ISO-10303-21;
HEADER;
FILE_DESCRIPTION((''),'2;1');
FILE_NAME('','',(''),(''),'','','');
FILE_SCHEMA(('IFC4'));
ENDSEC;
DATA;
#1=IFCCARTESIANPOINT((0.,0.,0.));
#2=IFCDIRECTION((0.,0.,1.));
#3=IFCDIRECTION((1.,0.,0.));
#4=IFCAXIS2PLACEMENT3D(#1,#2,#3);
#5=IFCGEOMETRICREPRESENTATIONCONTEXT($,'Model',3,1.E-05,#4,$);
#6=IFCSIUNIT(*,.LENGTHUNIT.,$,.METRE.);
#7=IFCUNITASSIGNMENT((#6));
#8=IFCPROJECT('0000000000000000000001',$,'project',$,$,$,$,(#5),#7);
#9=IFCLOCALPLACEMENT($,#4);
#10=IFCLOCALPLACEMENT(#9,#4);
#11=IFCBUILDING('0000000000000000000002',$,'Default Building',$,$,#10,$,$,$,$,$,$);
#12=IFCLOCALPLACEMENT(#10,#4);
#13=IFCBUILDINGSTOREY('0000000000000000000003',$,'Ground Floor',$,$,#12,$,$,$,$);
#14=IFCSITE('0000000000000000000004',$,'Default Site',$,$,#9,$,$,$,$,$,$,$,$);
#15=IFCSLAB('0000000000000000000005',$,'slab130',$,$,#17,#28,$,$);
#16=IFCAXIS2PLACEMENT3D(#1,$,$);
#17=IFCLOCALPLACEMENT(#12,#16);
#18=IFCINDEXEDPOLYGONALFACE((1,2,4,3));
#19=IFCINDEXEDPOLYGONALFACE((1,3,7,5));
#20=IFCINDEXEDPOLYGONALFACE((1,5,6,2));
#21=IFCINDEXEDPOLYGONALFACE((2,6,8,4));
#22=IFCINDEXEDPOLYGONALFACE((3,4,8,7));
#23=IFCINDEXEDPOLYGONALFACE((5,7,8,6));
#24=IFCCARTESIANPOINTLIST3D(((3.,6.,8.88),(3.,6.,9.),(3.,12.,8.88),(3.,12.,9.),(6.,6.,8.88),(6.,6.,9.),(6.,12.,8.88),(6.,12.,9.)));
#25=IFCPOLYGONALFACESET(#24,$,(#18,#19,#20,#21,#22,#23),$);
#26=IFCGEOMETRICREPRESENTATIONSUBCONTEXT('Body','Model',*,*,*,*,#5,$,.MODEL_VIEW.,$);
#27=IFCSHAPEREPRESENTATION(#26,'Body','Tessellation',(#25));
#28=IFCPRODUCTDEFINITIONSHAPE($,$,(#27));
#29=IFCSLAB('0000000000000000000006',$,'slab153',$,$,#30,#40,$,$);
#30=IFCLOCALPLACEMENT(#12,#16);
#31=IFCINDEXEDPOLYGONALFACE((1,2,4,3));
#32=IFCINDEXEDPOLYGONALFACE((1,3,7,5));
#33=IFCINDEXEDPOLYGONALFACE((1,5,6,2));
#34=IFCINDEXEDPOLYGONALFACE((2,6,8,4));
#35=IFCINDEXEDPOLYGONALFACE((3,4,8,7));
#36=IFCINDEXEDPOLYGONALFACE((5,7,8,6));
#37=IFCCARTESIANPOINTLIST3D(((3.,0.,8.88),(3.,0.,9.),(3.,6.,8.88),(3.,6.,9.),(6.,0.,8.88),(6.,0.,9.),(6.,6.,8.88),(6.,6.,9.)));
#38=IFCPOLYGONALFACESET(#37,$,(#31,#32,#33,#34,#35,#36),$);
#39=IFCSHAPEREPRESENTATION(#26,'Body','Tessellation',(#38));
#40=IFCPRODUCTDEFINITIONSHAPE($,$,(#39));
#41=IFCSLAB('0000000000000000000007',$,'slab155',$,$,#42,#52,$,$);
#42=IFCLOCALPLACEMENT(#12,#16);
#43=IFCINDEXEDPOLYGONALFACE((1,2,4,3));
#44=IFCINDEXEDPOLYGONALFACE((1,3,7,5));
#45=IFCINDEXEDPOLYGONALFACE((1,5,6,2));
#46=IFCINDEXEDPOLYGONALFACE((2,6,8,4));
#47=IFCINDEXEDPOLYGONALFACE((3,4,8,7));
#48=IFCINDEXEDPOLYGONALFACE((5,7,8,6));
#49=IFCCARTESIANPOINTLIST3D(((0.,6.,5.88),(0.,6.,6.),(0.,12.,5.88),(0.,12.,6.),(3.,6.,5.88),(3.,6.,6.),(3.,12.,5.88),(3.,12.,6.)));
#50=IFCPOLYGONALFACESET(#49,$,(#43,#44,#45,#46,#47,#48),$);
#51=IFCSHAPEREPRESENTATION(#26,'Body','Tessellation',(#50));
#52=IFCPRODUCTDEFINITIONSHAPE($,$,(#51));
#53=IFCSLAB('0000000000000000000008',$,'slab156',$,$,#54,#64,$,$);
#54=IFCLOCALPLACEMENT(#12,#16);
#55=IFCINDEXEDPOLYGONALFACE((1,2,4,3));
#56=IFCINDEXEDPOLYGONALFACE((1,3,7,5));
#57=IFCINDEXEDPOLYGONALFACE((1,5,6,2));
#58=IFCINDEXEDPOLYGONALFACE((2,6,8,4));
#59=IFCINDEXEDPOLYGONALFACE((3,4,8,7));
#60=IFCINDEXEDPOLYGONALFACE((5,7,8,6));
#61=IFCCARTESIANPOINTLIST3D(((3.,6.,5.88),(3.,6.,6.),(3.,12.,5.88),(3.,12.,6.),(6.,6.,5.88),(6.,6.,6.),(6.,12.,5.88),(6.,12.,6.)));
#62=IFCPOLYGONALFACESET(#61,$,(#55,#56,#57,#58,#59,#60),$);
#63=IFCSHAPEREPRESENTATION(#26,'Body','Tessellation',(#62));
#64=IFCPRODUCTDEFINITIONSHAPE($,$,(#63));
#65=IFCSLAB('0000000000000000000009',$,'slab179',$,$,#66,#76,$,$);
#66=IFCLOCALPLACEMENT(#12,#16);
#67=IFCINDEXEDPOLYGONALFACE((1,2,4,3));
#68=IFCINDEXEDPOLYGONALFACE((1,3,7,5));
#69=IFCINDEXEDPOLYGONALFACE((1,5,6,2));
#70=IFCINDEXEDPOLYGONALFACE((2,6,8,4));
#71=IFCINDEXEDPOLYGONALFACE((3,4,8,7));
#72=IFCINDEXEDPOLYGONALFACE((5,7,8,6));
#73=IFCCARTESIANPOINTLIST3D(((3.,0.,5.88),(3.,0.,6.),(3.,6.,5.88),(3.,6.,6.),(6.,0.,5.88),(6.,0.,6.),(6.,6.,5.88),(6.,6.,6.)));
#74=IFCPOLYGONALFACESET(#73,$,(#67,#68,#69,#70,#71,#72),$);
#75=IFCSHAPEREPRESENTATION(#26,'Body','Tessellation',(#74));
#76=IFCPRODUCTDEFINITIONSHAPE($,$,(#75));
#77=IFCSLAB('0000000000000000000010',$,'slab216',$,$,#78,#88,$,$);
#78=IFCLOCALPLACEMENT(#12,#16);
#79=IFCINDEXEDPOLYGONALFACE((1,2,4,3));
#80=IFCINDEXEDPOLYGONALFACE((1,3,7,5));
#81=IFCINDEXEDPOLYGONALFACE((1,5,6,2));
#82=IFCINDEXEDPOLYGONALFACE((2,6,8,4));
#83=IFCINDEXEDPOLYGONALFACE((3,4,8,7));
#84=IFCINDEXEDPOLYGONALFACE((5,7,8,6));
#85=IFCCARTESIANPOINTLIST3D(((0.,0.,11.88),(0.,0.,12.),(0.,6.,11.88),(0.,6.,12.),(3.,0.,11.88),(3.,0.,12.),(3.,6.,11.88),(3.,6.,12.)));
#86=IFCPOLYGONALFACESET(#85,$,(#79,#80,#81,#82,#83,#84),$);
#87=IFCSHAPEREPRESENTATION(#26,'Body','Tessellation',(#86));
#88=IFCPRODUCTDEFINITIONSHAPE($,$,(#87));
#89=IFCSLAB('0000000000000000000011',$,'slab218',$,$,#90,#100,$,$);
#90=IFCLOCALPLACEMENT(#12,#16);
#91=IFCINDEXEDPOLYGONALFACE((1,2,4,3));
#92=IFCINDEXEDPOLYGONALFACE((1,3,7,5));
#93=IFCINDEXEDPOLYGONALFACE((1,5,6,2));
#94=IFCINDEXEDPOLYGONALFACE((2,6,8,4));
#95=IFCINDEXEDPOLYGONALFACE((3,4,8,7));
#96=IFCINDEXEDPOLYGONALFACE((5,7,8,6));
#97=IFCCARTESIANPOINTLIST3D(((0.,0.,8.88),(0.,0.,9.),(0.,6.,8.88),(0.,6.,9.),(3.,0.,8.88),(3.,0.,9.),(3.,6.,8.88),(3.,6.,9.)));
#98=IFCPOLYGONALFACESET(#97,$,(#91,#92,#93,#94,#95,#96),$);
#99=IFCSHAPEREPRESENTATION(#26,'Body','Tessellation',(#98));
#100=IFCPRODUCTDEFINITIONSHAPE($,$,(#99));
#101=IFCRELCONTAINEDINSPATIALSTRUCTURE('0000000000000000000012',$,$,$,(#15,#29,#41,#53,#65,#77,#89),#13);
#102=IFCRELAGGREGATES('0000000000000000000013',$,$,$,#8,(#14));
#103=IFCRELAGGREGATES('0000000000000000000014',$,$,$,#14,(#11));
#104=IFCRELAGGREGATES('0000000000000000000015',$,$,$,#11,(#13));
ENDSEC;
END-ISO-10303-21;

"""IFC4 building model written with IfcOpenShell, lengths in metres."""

from ifc_helpers import new_model, si_unit, frame, origin_with_axes, place, context, subcontext, project, spatial, indexed_curve, outline, extrude, element, save


model = new_model("IFC4")

# Units and contexts
model_context = context("Model", 3, precision=1e-05, world=origin_with_axes())
body_context = subcontext(model_context, "Body", "Model", "MODEL_VIEW")
ifc_project = project(units=[si_unit("LENGTHUNIT", "METRE")], contexts=[model_context])

# Site, building, storey
site_placement = place(None, origin_with_axes())
site = spatial("IfcSite", under=ifc_project, at=site_placement, Name="Default Site")
building_placement = place(site_placement, origin_with_axes())
building = spatial("IfcBuilding", under=site, at=building_placement, Name="Default Building")
storey_placement = place(building_placement, origin_with_axes())
storey = spatial("IfcBuildingStorey", under=building, at=storey_placement, Name="Ground Floor")

# Slabs
for number, where, z_axis, x_axis, name in (
    (1, (3.0, 6.0, 8.88), (0.0, 0.0, 1.0), (1.0, 0.0, 0.0), "slab130"),
    (2, (3.0, 0.0, 8.88), (0.0, 0.0, 1.0), (1.0, 0.0, 0.0), "slab153"),
    (3, (0.0, 6.0, 5.88), (0.0, 0.0, 1.0), (1.0, 0.0, 0.0), "slab155"),
    (4, (3.0, 6.0, 5.88), (0.0, 0.0, 1.0), (1.0, 0.0, 0.0), "slab156"),
    (5, (3.0, 0.0, 5.88), (0.0, 0.0, 1.0), (1.0, 0.0, 0.0), "slab179"),
    (6, (0.0, 0.0, 11.88), (0.0, 0.0, 1.0), (1.0, 0.0, 0.0), "slab216"),
    (7, (0.0, 0.0, 8.88), (0.0, 0.0, 1.0), (1.0, 0.0, 0.0), "slab218"),
):
    element("IfcSlab", number, at=place(storey_placement, frame(where, z_axis=z_axis, x_axis=x_axis)), inside=storey, Name=name, context=body_context, shape_type="SweptSolid", body=[
        extrude(outline(indexed_curve([(0.0, 0.0), (0.0, 6.0), (3.0, 6.0), (3.0, 0.0), (0.0, 0.0)], self_intersect=False)), origin_with_axes(), (0.0, 0.0, 1.0), 0.12),
    ])

save(model, "model.ifc")
